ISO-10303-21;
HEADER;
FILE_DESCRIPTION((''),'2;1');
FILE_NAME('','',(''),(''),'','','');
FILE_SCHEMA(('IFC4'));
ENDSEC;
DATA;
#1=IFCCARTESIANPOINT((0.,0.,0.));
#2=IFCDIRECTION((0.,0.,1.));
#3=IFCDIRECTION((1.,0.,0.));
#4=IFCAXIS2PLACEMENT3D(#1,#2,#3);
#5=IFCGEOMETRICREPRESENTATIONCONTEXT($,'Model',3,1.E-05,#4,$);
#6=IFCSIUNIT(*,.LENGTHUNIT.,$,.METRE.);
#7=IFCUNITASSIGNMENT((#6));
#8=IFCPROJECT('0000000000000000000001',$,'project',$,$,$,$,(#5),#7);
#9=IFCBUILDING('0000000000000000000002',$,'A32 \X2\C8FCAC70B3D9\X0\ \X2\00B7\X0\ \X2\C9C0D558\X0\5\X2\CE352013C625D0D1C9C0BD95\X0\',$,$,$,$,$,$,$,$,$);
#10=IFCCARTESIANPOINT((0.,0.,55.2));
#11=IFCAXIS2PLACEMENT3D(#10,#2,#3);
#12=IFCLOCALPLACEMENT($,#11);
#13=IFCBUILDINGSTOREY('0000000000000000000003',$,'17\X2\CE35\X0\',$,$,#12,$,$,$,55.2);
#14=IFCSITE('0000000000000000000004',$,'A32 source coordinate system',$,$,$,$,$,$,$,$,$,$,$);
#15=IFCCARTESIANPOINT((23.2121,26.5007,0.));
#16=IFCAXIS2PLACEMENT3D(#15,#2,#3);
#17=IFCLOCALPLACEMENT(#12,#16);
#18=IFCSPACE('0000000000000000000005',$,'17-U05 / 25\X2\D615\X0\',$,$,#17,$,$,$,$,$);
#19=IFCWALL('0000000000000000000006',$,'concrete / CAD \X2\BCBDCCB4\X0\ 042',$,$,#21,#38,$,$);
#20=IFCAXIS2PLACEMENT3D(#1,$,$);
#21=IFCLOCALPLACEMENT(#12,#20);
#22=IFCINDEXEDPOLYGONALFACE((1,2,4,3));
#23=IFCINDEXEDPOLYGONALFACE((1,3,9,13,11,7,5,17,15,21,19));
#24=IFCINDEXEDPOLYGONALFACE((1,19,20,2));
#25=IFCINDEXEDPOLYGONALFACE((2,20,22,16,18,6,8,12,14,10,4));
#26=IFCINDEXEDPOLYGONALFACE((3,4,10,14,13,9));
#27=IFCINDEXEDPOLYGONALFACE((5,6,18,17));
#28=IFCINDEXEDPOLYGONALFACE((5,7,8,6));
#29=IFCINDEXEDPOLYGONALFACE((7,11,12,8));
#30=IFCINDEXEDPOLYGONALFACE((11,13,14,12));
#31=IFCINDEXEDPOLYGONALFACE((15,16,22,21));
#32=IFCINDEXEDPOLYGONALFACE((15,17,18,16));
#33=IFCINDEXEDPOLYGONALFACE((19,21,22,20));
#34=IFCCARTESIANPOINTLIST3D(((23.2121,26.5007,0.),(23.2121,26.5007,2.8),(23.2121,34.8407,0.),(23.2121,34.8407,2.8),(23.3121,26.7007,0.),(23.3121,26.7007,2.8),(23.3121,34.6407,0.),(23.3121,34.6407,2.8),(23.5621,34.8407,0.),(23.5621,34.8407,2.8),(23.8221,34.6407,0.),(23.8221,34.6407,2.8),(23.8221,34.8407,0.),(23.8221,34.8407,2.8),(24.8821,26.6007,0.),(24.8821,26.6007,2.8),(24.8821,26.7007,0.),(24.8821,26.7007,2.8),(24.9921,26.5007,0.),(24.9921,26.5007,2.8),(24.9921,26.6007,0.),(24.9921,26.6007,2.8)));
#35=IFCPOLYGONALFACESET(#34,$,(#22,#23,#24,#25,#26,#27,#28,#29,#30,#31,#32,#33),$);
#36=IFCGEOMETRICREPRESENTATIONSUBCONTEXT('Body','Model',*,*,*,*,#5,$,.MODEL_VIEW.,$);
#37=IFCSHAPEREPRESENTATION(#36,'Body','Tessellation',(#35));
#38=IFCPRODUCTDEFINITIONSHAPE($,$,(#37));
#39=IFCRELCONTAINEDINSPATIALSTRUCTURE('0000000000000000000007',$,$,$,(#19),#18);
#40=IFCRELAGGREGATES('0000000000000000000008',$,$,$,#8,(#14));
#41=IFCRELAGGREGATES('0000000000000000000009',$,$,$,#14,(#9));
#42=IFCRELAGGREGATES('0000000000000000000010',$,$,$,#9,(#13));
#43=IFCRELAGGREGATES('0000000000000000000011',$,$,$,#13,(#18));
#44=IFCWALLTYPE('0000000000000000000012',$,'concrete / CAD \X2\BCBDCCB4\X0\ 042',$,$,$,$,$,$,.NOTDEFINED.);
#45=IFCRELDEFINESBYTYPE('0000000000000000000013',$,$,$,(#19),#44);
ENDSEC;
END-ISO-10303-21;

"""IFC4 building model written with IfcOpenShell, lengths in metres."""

from ifc_helpers import new_model, si_unit, frame, origin, origin_with_axes, place, context, subcontext, project, spatial, polyline, outline, extrude, source, transform, mapped, type_object, type_shapes, element, save


model = new_model("IFC4")

# Units and contexts
model_context = context("Model", 3, precision=1e-05, world=origin_with_axes())
body_context = subcontext(model_context, "Body", "Model", "MODEL_VIEW")
ifc_project = project(units=[si_unit("LENGTHUNIT", "METRE")], contexts=[model_context])

# Site, building, storey, space
site = spatial("IfcSite", under=ifc_project, Name="A32 source coordinate system")
building = spatial("IfcBuilding", under=site, Name="A32 주거동 · 지하5층–옥탑지붕")
storey_placement = place(None, frame((0.0, 0.0, 55.2), z_axis=(0.0, 0.0, 1.0), x_axis=(1.0, 0.0, 0.0)))
storey = spatial("IfcBuildingStorey", under=building, at=storey_placement, Name="17층", Elevation=55.2)
space_1_placement = place(storey_placement, frame((23.2121, 26.5007, 0.0), z_axis=(0.0, 0.0, 1.0), x_axis=(1.0, 0.0, 0.0)))
space_1 = spatial("IfcSpace", under=storey, at=space_1_placement, Name="17-U05 / 25형")

# Wall
wall_type_1 = type_object("IfcWallType", Name="concrete / CAD 벽체 042", PredefinedType="NOTDEFINED")
shared_shape_1 = source(origin(), body_context, "Body", "SweptSolid", [
    extrude(outline(polyline([(0.1, 8.14), (0.1, 0.2), (1.67, 0.2), (1.67, 0.1), (1.78, 0.1), (1.78, 0.0), (0.0, 0.0), (0.0, 8.34), (0.35, 8.34), (0.35, 8.34), (0.61, 8.34), (0.61, 8.14), (0.1, 8.14)])), origin(), (0.0, 0.0, 1.0), 2.8),
])
type_shapes(wall_type_1, [shared_shape_1])
wall_1_placement = place(space_1_placement, origin_with_axes())
element("IfcWall", 1, at=wall_1_placement, inside=space_1, type_object=wall_type_1, Name="concrete / CAD 벽체 042", context=body_context, shape_type="MappedRepresentation", body=[
    mapped(shared_shape_1, transform((0.0, 0.0, 0.0), scale=1.0)),
])

save(model, "model.ifc")
